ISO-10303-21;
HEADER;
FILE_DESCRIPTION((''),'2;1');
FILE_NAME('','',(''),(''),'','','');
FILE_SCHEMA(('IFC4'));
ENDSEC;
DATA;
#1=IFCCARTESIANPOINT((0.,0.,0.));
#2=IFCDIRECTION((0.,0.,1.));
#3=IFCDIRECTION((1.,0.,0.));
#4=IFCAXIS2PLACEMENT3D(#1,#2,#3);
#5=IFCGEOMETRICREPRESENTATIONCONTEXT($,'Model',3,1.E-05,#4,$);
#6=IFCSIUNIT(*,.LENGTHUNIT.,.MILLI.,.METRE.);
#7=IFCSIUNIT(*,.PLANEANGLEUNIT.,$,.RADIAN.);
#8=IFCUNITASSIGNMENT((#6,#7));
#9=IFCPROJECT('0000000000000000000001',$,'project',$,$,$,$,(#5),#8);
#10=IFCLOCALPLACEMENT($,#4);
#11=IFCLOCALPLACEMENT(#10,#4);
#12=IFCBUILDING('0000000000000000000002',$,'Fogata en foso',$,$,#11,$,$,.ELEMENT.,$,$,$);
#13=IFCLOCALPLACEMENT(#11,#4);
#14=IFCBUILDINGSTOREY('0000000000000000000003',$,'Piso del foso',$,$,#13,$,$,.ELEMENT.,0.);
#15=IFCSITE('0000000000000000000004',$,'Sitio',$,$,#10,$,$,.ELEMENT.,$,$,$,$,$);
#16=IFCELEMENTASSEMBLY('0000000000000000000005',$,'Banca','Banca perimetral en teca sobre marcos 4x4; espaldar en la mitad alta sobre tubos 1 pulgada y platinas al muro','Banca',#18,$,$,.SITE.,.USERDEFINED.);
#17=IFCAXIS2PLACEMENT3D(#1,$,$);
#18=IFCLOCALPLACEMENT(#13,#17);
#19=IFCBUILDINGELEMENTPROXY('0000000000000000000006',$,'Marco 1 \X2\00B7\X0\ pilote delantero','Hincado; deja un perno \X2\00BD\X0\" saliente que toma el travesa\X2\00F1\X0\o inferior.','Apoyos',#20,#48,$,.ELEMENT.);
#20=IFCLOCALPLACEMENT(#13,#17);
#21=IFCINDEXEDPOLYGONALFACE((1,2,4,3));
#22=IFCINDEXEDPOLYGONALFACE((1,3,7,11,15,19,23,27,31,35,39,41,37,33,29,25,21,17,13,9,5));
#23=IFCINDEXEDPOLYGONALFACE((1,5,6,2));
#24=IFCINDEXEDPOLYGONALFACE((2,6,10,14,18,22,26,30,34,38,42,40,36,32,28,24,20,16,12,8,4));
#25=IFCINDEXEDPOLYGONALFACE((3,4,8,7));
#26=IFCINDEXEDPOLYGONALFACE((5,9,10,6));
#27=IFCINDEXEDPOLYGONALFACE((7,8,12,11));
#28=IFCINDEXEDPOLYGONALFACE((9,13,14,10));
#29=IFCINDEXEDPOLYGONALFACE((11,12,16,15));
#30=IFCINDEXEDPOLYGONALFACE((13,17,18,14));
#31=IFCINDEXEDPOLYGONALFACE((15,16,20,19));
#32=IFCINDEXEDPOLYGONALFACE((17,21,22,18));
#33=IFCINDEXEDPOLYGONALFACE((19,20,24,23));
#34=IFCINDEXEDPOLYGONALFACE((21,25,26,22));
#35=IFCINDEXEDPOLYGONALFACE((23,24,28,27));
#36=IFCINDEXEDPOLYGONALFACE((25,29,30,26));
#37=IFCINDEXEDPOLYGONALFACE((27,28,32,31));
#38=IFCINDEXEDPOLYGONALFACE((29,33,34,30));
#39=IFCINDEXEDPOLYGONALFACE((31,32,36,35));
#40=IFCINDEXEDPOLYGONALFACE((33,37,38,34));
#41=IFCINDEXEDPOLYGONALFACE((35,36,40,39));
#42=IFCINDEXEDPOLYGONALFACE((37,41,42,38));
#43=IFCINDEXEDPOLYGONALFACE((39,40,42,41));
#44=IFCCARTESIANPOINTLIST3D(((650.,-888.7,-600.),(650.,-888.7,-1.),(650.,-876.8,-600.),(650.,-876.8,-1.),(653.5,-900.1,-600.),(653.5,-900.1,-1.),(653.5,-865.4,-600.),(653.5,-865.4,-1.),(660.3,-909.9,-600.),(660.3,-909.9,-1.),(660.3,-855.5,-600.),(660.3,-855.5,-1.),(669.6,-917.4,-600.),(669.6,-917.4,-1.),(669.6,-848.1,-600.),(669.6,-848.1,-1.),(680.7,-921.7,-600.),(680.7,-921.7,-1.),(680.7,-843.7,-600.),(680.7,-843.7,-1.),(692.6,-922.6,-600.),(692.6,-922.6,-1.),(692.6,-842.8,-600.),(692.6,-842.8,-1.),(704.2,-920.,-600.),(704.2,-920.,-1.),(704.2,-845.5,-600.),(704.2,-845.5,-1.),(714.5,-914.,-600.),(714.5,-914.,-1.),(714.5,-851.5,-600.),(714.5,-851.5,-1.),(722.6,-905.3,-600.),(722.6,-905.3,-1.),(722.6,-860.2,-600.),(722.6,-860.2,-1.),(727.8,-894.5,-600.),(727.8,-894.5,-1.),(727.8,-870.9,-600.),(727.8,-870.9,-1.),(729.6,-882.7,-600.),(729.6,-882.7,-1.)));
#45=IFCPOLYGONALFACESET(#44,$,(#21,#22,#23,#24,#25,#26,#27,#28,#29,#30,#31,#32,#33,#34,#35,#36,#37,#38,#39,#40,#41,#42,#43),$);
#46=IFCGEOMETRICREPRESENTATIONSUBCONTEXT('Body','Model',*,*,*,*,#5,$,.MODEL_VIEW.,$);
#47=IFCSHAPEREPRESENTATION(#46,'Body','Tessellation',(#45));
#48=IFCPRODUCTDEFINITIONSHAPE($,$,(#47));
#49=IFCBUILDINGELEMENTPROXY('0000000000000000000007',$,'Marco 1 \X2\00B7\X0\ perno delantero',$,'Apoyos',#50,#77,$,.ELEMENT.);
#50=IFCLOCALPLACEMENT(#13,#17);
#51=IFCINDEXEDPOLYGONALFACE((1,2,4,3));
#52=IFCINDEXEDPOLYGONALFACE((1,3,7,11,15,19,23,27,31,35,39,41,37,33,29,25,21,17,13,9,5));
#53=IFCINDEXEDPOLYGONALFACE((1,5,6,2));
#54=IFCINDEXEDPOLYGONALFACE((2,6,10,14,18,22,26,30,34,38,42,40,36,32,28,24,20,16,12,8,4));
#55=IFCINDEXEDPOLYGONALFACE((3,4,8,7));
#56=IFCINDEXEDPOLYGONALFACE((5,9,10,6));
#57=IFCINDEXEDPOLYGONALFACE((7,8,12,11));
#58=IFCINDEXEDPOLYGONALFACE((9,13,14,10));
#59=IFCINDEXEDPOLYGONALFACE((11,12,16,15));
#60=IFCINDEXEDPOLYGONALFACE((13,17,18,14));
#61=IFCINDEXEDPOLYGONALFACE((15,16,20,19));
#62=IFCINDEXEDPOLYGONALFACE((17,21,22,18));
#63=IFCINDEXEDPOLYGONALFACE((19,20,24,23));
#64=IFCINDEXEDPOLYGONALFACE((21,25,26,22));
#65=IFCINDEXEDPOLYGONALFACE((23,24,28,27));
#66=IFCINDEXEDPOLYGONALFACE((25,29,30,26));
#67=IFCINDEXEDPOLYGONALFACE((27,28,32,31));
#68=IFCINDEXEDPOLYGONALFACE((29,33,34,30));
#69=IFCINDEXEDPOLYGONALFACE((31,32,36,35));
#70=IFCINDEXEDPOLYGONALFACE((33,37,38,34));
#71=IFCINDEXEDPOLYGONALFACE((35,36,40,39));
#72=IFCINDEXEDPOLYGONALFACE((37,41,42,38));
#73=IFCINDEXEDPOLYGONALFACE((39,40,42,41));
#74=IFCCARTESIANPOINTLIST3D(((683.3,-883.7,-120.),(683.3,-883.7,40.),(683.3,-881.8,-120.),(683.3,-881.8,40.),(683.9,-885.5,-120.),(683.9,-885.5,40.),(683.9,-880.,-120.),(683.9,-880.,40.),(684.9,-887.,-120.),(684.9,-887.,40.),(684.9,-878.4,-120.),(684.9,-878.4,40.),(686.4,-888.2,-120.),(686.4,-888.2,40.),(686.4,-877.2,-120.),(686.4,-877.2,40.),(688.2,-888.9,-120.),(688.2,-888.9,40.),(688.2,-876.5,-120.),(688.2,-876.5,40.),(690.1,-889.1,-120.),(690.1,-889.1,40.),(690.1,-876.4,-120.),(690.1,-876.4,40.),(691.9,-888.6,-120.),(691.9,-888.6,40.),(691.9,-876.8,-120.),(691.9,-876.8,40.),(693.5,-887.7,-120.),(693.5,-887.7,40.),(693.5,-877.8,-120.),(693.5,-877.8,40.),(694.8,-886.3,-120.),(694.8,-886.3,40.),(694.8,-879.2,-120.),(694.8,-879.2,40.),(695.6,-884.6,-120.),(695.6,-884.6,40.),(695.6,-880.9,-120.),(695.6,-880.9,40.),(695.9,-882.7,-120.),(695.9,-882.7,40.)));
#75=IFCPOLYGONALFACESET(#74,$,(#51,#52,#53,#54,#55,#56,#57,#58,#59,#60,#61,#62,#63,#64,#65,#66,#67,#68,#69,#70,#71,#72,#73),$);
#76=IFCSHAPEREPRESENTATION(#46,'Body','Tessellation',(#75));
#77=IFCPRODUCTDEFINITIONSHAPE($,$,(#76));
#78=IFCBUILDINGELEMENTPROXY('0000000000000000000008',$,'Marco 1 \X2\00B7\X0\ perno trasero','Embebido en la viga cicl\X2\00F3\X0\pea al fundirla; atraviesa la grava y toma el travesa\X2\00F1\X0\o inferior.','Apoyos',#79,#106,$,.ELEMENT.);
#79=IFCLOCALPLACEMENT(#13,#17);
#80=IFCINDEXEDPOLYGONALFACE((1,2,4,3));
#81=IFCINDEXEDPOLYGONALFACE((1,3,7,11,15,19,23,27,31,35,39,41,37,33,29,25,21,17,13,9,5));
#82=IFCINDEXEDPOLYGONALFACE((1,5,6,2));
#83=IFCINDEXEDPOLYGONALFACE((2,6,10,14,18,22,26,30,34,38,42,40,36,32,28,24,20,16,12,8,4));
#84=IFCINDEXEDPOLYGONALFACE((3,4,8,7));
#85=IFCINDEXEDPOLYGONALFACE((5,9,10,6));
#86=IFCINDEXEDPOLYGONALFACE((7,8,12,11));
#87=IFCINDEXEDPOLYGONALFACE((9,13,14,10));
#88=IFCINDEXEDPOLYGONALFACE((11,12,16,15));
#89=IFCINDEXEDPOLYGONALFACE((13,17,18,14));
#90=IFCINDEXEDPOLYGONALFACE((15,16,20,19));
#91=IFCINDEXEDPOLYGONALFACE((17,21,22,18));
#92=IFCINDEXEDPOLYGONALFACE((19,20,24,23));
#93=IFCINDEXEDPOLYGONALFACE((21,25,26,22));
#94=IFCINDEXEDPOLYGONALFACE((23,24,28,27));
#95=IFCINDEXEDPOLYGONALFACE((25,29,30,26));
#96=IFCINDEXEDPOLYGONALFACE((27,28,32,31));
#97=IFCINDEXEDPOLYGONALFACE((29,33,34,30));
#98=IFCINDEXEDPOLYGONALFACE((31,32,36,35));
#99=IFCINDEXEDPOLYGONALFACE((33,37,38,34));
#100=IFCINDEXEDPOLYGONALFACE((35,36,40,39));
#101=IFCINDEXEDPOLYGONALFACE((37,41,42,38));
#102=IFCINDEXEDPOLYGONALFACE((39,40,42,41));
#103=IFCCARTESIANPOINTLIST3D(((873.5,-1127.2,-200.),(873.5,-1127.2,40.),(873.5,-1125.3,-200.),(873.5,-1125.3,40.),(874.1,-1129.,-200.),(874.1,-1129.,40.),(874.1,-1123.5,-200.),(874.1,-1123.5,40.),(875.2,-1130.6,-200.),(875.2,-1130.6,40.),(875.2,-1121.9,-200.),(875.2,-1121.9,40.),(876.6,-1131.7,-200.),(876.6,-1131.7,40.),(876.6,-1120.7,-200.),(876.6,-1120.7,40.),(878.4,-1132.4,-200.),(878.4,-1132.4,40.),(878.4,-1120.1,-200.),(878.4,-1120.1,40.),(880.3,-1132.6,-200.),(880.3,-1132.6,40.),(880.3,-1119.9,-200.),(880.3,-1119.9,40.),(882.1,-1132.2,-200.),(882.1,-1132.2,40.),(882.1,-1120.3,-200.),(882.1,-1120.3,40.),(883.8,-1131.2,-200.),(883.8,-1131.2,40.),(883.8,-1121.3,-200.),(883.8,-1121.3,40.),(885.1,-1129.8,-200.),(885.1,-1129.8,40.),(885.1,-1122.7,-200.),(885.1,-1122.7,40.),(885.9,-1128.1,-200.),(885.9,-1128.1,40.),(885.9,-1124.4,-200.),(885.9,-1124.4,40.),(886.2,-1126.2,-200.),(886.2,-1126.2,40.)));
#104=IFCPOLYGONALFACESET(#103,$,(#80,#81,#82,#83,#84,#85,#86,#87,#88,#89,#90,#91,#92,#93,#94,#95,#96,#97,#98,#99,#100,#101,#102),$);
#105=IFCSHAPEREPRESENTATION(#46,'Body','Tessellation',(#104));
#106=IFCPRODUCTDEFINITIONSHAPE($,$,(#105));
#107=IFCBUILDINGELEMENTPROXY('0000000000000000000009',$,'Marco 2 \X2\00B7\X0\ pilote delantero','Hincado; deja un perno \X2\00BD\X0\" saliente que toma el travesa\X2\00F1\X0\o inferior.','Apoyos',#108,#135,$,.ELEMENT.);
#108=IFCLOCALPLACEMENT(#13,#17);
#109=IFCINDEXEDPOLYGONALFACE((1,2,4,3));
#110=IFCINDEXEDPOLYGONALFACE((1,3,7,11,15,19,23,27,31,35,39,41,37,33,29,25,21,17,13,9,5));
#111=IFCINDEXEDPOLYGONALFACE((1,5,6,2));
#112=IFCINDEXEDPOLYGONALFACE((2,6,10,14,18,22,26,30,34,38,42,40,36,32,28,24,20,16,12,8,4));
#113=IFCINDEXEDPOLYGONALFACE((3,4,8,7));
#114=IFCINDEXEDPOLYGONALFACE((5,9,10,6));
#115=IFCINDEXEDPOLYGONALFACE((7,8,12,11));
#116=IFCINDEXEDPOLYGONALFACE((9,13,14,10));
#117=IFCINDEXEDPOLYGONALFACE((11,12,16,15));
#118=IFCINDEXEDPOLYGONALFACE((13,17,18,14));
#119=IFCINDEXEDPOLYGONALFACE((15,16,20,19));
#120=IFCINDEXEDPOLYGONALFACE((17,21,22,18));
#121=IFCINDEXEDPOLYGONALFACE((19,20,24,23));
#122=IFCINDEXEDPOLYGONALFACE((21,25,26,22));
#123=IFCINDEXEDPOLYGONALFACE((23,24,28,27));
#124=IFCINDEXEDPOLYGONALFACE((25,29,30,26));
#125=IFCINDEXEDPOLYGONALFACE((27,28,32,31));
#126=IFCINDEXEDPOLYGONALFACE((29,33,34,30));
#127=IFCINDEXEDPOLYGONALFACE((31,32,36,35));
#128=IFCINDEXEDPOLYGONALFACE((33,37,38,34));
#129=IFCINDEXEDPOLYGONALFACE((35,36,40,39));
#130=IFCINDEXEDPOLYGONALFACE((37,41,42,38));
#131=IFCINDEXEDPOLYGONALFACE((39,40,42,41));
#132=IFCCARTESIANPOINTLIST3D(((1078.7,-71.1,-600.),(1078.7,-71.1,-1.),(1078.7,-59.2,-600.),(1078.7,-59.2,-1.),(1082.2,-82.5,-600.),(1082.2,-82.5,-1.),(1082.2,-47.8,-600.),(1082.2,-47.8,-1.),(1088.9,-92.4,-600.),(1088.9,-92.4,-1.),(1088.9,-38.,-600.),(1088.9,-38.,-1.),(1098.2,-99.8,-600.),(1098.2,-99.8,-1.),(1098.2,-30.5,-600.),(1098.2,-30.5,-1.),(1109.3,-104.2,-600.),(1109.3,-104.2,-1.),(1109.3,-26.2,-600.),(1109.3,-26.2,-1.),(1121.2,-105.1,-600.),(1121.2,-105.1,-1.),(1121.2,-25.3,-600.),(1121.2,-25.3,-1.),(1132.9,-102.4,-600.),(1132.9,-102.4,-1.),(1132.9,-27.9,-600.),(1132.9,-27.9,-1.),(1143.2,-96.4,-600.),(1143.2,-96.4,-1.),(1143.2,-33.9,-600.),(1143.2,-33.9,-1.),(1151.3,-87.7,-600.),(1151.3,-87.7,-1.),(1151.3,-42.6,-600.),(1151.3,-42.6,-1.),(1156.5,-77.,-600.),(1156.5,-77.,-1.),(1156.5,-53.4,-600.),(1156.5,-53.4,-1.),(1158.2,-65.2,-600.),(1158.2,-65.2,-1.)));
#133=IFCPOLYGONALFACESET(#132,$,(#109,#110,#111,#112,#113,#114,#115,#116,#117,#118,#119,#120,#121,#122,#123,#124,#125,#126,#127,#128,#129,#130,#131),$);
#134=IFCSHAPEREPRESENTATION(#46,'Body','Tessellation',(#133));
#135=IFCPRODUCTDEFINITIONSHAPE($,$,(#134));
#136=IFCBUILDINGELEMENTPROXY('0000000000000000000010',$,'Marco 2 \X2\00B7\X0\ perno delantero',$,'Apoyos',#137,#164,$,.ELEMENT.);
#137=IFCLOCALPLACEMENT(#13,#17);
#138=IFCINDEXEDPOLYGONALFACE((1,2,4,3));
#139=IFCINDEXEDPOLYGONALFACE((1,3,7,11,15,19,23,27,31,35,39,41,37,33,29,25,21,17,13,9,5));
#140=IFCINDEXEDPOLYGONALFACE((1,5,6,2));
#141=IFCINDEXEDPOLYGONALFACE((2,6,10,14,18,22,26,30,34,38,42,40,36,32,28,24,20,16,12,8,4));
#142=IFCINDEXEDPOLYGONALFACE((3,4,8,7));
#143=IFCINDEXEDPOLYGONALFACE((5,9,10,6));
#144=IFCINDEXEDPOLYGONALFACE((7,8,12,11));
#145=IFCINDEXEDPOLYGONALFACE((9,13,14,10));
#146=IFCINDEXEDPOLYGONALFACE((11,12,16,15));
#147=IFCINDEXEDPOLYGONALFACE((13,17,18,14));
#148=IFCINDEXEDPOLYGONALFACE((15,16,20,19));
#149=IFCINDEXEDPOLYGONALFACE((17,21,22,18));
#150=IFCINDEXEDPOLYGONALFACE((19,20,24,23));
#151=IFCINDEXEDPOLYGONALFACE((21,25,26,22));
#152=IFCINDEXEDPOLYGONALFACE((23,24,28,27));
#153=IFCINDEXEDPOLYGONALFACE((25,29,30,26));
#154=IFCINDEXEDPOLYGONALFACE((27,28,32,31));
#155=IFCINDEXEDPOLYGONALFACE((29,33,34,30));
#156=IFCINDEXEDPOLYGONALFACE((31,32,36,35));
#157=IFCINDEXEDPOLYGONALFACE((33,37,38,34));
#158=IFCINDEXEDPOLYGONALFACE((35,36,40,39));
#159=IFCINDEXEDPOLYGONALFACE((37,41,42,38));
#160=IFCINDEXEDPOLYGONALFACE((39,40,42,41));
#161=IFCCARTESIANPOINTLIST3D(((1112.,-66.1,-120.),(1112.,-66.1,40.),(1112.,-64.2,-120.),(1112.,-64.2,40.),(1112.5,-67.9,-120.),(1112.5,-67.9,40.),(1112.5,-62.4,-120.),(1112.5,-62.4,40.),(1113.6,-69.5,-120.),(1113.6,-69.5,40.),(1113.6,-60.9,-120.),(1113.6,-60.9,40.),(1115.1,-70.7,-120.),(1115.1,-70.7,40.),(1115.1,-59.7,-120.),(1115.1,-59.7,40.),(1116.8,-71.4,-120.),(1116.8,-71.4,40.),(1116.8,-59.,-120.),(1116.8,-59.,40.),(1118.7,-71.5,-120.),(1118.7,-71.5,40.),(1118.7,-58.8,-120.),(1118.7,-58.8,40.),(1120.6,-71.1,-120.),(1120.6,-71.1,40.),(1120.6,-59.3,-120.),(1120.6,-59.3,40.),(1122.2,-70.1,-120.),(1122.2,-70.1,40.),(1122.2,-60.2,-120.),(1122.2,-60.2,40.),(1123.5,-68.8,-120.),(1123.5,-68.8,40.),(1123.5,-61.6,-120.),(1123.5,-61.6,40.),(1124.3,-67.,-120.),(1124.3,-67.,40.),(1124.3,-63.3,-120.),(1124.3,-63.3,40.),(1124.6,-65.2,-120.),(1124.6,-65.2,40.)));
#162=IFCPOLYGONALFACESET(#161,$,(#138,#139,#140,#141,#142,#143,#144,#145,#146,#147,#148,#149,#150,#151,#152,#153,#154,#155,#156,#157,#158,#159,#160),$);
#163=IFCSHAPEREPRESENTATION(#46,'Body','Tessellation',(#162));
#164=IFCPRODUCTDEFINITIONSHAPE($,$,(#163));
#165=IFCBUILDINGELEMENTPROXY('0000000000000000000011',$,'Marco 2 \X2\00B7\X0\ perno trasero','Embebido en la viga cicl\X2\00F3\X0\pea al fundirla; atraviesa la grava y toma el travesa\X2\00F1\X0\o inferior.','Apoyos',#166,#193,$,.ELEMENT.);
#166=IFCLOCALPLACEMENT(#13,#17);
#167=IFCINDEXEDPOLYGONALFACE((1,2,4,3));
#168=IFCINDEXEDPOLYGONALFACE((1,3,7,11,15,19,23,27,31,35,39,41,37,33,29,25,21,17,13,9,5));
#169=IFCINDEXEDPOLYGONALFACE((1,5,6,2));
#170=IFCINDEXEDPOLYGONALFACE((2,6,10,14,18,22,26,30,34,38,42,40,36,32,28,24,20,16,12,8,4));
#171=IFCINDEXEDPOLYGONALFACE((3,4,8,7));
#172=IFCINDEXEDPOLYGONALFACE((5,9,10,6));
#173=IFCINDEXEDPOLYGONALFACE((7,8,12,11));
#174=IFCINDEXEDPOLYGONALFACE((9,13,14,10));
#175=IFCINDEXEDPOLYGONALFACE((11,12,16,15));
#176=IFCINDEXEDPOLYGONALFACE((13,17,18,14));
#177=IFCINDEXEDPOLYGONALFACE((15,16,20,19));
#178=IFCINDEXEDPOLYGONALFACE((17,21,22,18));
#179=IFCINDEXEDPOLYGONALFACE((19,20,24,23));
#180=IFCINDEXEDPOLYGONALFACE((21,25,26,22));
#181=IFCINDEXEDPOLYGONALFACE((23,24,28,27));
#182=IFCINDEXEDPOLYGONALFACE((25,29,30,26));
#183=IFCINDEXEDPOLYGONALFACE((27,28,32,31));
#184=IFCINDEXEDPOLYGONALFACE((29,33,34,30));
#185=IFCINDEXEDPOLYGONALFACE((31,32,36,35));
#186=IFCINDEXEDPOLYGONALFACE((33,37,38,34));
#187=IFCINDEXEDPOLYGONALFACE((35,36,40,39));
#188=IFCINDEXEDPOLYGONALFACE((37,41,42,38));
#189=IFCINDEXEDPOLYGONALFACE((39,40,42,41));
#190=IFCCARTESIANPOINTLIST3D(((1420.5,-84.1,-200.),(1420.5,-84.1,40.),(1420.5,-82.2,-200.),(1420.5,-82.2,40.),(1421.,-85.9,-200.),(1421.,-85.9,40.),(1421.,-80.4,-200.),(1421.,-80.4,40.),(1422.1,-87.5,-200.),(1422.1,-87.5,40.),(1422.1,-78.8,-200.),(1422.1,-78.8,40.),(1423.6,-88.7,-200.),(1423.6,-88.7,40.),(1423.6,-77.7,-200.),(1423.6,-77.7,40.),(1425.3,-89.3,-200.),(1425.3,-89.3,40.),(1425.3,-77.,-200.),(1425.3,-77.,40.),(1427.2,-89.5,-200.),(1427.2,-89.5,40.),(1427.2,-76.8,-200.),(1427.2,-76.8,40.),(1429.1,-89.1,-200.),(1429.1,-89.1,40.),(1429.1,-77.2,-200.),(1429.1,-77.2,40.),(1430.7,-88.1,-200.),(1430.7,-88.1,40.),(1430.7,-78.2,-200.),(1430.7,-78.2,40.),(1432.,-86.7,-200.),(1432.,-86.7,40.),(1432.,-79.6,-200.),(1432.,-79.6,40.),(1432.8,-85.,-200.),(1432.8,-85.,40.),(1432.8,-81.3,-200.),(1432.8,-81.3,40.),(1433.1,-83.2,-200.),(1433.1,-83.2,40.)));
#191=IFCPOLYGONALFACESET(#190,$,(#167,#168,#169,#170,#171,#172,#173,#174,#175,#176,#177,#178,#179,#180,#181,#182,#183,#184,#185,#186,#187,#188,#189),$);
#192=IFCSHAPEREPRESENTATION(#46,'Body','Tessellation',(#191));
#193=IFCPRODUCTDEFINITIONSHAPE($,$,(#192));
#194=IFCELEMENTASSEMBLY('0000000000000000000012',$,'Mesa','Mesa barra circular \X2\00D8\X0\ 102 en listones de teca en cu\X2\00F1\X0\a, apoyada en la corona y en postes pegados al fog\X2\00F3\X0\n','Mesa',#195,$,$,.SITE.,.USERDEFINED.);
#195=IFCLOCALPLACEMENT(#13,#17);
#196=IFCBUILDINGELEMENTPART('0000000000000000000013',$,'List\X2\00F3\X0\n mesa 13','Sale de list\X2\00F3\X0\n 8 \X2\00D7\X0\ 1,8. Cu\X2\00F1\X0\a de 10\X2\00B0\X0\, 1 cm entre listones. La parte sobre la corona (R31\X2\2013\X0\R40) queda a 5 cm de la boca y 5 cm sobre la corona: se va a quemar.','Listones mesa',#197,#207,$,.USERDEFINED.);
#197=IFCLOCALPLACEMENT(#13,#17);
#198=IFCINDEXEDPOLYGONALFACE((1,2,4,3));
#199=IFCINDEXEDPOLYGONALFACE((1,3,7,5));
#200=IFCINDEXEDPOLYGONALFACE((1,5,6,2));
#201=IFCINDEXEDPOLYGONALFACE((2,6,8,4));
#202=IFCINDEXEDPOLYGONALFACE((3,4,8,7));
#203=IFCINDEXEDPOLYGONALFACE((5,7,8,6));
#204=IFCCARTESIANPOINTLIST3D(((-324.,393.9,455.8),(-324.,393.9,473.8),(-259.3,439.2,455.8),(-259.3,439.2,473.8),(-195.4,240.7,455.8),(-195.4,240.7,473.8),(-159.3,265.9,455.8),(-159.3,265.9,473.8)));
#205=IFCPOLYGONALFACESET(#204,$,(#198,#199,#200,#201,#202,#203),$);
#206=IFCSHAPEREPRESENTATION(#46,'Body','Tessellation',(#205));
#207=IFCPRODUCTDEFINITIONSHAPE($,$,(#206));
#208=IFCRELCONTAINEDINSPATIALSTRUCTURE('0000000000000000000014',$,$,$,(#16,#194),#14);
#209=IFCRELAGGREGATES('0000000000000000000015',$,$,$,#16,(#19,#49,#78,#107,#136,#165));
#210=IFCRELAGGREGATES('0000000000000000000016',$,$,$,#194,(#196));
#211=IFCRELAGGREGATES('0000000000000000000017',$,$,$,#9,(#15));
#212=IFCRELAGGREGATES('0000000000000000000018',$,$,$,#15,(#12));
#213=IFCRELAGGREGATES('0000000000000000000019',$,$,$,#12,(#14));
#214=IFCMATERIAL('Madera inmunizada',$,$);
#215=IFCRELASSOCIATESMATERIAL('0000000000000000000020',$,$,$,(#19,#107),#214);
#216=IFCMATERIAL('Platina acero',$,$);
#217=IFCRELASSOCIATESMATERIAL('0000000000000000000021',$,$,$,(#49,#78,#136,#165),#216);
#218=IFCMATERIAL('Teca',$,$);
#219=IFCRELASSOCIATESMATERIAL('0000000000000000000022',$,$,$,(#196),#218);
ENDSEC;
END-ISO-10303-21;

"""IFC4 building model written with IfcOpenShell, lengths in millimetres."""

from ifc_helpers import new_model, si_unit, frame, origin_with_axes, origin_2d, place, context, subcontext, project, spatial, polyline, circle, outline, extrude, material, element, aggregate, save


model = new_model("IFC4")

# Units and contexts
model_context = context("Model", 3, precision=1e-05, world=origin_with_axes())
body_context = subcontext(model_context, "Body", "Model", "MODEL_VIEW")
ifc_project = project(units=[si_unit("LENGTHUNIT", "METRE", prefix="MILLI"), si_unit("PLANEANGLEUNIT", "RADIAN")], contexts=[model_context])

# Site, building, storey
site_placement = place(None, origin_with_axes())
site = spatial("IfcSite", under=ifc_project, at=site_placement, Name="Sitio", CompositionType="ELEMENT")
building_placement = place(site_placement, origin_with_axes())
building = spatial("IfcBuilding", under=site, at=building_placement, Name="Fogata en foso", CompositionType="ELEMENT")
storey_placement = place(building_placement, origin_with_axes())
storey = spatial("IfcBuildingStorey", under=building, at=storey_placement, Name="Piso del foso", CompositionType="ELEMENT", Elevation=0.0)

# Element assembly, building element proxies
assembly_1_placement = place(storey_placement, origin_with_axes())
assembly_1 = element("IfcElementAssembly", 1, at=assembly_1_placement, inside=storey, Name="Banca", Description="Banca perimetral en teca sobre marcos 4x4; espaldar en la mitad alta sobre tubos 1 pulgada y platinas al muro", ObjectType="Banca", AssemblyPlace="SITE", PredefinedType="USERDEFINED")
ifc_material_1 = material(Name="Teca")
ifc_material_2 = material(Name="Madera inmunizada")
proxy_1_placement = place(storey_placement, frame((689.6, -882.7, -600.0), z_axis=(0.0, 0.0, 1.0), x_axis=(1.0, 0.0, 0.0)))
proxy_1 = element("IfcBuildingElementProxy", 2, at=proxy_1_placement, material=ifc_material_2, Name="Marco 1 · pilote delantero", Description="Hincado; deja un perno ½\" saliente que toma el travesaño inferior.", ObjectType="Apoyos", PredefinedType="ELEMENT", context=body_context, shape_type="SweptSolid", body=[
    extrude(circle(Radius=40.0, at=origin_2d()), origin_with_axes(), (0.0, 0.0, 1.0), 599.0),
])
ifc_material_3 = material(Name="Platina acero")
proxy_2_placement = place(storey_placement, frame((689.6, -882.7, -120.0), z_axis=(0.0, 0.0, 1.0), x_axis=(1.0, 0.0, 0.0)))
proxy_2 = element("IfcBuildingElementProxy", 3, at=proxy_2_placement, material=ifc_material_3, Name="Marco 1 · perno delantero", ObjectType="Apoyos", PredefinedType="ELEMENT", context=body_context, shape_type="SweptSolid", body=[
    extrude(circle(Radius=6.3, at=origin_2d()), origin_with_axes(), (0.0, 0.0, 1.0), 160.0),
])
proxy_3_placement = place(storey_placement, frame((879.8, -1126.2, -200.0), z_axis=(0.0, 0.0, 1.0), x_axis=(1.0, 0.0, 0.0)))
proxy_3 = element("IfcBuildingElementProxy", 4, at=proxy_3_placement, material=ifc_material_3, Name="Marco 1 · perno trasero", Description="Embebido en la viga ciclópea al fundirla; atraviesa la grava y toma el travesaño inferior.", ObjectType="Apoyos", PredefinedType="ELEMENT", context=body_context, shape_type="SweptSolid", body=[
    extrude(circle(Radius=6.3, at=origin_2d()), origin_with_axes(), (0.0, 0.0, 1.0), 240.0),
])
proxy_4_placement = place(storey_placement, frame((1118.2, -65.2, -600.0), z_axis=(0.0, 0.0, 1.0), x_axis=(1.0, 0.0, 0.0)))
proxy_4 = element("IfcBuildingElementProxy", 5, at=proxy_4_placement, material=ifc_material_2, Name="Marco 2 · pilote delantero", Description="Hincado; deja un perno ½\" saliente que toma el travesaño inferior.", ObjectType="Apoyos", PredefinedType="ELEMENT", context=body_context, shape_type="SweptSolid", body=[
    extrude(circle(Radius=40.0, at=origin_2d()), origin_with_axes(), (0.0, 0.0, 1.0), 599.0),
])
proxy_5_placement = place(storey_placement, frame((1118.2, -65.2, -120.0), z_axis=(0.0, 0.0, 1.0), x_axis=(1.0, 0.0, 0.0)))
proxy_5 = element("IfcBuildingElementProxy", 6, at=proxy_5_placement, material=ifc_material_3, Name="Marco 2 · perno delantero", ObjectType="Apoyos", PredefinedType="ELEMENT", context=body_context, shape_type="SweptSolid", body=[
    extrude(circle(Radius=6.3, at=origin_2d()), origin_with_axes(), (0.0, 0.0, 1.0), 160.0),
])
proxy_6_placement = place(storey_placement, frame((1426.7, -83.2, -200.0), z_axis=(0.0, 0.0, 1.0), x_axis=(1.0, 0.0, 0.0)))
proxy_6 = element("IfcBuildingElementProxy", 7, at=proxy_6_placement, material=ifc_material_3, Name="Marco 2 · perno trasero", Description="Embebido en la viga ciclópea al fundirla; atraviesa la grava y toma el travesaño inferior.", ObjectType="Apoyos", PredefinedType="ELEMENT", context=body_context, shape_type="SweptSolid", body=[
    extrude(circle(Radius=6.3, at=origin_2d()), origin_with_axes(), (0.0, 0.0, 1.0), 240.0),
])
aggregate(assembly_1, [proxy_1, proxy_2, proxy_3, proxy_4, proxy_5, proxy_6])

# Element assembly, building element part
assembly_2_placement = place(storey_placement, origin_with_axes())
assembly_2 = element("IfcElementAssembly", 8, at=assembly_2_placement, inside=storey, Name="Mesa", Description="Mesa barra circular Ø 102 en listones de teca en cuña, apoyada en la corona y en postes pegados al fogón", ObjectType="Mesa", AssemblyPlace="SITE", PredefinedType="USERDEFINED")
building_element_part_1_placement = place(storey_placement, frame((0.0, 0.0, 455.8), z_axis=(0.0, 0.0, 1.0), x_axis=(1.0, 0.0, 0.0)))
building_element_part_1 = element("IfcBuildingElementPart", 9, at=building_element_part_1_placement, material=ifc_material_1, Name="Listón mesa 13", Description="Sale de listón 8 × 1,8. Cuña de 10°, 1 cm entre listones. La parte sobre la corona (R31–R40) queda a 5 cm de la boca y 5 cm sobre la corona: se va a quemar.", ObjectType="Listones mesa", PredefinedType="USERDEFINED", context=body_context, shape_type="SweptSolid", body=[
    extrude(outline(polyline([(-159.3, 265.9), (-259.3, 439.2), (-324.0, 393.9), (-195.4, 240.7), (-159.3, 265.9)])), origin_with_axes(), (0.0, 0.0, 1.0), 18.0),
])
aggregate(assembly_2, [building_element_part_1])

save(model, "model.ifc")
